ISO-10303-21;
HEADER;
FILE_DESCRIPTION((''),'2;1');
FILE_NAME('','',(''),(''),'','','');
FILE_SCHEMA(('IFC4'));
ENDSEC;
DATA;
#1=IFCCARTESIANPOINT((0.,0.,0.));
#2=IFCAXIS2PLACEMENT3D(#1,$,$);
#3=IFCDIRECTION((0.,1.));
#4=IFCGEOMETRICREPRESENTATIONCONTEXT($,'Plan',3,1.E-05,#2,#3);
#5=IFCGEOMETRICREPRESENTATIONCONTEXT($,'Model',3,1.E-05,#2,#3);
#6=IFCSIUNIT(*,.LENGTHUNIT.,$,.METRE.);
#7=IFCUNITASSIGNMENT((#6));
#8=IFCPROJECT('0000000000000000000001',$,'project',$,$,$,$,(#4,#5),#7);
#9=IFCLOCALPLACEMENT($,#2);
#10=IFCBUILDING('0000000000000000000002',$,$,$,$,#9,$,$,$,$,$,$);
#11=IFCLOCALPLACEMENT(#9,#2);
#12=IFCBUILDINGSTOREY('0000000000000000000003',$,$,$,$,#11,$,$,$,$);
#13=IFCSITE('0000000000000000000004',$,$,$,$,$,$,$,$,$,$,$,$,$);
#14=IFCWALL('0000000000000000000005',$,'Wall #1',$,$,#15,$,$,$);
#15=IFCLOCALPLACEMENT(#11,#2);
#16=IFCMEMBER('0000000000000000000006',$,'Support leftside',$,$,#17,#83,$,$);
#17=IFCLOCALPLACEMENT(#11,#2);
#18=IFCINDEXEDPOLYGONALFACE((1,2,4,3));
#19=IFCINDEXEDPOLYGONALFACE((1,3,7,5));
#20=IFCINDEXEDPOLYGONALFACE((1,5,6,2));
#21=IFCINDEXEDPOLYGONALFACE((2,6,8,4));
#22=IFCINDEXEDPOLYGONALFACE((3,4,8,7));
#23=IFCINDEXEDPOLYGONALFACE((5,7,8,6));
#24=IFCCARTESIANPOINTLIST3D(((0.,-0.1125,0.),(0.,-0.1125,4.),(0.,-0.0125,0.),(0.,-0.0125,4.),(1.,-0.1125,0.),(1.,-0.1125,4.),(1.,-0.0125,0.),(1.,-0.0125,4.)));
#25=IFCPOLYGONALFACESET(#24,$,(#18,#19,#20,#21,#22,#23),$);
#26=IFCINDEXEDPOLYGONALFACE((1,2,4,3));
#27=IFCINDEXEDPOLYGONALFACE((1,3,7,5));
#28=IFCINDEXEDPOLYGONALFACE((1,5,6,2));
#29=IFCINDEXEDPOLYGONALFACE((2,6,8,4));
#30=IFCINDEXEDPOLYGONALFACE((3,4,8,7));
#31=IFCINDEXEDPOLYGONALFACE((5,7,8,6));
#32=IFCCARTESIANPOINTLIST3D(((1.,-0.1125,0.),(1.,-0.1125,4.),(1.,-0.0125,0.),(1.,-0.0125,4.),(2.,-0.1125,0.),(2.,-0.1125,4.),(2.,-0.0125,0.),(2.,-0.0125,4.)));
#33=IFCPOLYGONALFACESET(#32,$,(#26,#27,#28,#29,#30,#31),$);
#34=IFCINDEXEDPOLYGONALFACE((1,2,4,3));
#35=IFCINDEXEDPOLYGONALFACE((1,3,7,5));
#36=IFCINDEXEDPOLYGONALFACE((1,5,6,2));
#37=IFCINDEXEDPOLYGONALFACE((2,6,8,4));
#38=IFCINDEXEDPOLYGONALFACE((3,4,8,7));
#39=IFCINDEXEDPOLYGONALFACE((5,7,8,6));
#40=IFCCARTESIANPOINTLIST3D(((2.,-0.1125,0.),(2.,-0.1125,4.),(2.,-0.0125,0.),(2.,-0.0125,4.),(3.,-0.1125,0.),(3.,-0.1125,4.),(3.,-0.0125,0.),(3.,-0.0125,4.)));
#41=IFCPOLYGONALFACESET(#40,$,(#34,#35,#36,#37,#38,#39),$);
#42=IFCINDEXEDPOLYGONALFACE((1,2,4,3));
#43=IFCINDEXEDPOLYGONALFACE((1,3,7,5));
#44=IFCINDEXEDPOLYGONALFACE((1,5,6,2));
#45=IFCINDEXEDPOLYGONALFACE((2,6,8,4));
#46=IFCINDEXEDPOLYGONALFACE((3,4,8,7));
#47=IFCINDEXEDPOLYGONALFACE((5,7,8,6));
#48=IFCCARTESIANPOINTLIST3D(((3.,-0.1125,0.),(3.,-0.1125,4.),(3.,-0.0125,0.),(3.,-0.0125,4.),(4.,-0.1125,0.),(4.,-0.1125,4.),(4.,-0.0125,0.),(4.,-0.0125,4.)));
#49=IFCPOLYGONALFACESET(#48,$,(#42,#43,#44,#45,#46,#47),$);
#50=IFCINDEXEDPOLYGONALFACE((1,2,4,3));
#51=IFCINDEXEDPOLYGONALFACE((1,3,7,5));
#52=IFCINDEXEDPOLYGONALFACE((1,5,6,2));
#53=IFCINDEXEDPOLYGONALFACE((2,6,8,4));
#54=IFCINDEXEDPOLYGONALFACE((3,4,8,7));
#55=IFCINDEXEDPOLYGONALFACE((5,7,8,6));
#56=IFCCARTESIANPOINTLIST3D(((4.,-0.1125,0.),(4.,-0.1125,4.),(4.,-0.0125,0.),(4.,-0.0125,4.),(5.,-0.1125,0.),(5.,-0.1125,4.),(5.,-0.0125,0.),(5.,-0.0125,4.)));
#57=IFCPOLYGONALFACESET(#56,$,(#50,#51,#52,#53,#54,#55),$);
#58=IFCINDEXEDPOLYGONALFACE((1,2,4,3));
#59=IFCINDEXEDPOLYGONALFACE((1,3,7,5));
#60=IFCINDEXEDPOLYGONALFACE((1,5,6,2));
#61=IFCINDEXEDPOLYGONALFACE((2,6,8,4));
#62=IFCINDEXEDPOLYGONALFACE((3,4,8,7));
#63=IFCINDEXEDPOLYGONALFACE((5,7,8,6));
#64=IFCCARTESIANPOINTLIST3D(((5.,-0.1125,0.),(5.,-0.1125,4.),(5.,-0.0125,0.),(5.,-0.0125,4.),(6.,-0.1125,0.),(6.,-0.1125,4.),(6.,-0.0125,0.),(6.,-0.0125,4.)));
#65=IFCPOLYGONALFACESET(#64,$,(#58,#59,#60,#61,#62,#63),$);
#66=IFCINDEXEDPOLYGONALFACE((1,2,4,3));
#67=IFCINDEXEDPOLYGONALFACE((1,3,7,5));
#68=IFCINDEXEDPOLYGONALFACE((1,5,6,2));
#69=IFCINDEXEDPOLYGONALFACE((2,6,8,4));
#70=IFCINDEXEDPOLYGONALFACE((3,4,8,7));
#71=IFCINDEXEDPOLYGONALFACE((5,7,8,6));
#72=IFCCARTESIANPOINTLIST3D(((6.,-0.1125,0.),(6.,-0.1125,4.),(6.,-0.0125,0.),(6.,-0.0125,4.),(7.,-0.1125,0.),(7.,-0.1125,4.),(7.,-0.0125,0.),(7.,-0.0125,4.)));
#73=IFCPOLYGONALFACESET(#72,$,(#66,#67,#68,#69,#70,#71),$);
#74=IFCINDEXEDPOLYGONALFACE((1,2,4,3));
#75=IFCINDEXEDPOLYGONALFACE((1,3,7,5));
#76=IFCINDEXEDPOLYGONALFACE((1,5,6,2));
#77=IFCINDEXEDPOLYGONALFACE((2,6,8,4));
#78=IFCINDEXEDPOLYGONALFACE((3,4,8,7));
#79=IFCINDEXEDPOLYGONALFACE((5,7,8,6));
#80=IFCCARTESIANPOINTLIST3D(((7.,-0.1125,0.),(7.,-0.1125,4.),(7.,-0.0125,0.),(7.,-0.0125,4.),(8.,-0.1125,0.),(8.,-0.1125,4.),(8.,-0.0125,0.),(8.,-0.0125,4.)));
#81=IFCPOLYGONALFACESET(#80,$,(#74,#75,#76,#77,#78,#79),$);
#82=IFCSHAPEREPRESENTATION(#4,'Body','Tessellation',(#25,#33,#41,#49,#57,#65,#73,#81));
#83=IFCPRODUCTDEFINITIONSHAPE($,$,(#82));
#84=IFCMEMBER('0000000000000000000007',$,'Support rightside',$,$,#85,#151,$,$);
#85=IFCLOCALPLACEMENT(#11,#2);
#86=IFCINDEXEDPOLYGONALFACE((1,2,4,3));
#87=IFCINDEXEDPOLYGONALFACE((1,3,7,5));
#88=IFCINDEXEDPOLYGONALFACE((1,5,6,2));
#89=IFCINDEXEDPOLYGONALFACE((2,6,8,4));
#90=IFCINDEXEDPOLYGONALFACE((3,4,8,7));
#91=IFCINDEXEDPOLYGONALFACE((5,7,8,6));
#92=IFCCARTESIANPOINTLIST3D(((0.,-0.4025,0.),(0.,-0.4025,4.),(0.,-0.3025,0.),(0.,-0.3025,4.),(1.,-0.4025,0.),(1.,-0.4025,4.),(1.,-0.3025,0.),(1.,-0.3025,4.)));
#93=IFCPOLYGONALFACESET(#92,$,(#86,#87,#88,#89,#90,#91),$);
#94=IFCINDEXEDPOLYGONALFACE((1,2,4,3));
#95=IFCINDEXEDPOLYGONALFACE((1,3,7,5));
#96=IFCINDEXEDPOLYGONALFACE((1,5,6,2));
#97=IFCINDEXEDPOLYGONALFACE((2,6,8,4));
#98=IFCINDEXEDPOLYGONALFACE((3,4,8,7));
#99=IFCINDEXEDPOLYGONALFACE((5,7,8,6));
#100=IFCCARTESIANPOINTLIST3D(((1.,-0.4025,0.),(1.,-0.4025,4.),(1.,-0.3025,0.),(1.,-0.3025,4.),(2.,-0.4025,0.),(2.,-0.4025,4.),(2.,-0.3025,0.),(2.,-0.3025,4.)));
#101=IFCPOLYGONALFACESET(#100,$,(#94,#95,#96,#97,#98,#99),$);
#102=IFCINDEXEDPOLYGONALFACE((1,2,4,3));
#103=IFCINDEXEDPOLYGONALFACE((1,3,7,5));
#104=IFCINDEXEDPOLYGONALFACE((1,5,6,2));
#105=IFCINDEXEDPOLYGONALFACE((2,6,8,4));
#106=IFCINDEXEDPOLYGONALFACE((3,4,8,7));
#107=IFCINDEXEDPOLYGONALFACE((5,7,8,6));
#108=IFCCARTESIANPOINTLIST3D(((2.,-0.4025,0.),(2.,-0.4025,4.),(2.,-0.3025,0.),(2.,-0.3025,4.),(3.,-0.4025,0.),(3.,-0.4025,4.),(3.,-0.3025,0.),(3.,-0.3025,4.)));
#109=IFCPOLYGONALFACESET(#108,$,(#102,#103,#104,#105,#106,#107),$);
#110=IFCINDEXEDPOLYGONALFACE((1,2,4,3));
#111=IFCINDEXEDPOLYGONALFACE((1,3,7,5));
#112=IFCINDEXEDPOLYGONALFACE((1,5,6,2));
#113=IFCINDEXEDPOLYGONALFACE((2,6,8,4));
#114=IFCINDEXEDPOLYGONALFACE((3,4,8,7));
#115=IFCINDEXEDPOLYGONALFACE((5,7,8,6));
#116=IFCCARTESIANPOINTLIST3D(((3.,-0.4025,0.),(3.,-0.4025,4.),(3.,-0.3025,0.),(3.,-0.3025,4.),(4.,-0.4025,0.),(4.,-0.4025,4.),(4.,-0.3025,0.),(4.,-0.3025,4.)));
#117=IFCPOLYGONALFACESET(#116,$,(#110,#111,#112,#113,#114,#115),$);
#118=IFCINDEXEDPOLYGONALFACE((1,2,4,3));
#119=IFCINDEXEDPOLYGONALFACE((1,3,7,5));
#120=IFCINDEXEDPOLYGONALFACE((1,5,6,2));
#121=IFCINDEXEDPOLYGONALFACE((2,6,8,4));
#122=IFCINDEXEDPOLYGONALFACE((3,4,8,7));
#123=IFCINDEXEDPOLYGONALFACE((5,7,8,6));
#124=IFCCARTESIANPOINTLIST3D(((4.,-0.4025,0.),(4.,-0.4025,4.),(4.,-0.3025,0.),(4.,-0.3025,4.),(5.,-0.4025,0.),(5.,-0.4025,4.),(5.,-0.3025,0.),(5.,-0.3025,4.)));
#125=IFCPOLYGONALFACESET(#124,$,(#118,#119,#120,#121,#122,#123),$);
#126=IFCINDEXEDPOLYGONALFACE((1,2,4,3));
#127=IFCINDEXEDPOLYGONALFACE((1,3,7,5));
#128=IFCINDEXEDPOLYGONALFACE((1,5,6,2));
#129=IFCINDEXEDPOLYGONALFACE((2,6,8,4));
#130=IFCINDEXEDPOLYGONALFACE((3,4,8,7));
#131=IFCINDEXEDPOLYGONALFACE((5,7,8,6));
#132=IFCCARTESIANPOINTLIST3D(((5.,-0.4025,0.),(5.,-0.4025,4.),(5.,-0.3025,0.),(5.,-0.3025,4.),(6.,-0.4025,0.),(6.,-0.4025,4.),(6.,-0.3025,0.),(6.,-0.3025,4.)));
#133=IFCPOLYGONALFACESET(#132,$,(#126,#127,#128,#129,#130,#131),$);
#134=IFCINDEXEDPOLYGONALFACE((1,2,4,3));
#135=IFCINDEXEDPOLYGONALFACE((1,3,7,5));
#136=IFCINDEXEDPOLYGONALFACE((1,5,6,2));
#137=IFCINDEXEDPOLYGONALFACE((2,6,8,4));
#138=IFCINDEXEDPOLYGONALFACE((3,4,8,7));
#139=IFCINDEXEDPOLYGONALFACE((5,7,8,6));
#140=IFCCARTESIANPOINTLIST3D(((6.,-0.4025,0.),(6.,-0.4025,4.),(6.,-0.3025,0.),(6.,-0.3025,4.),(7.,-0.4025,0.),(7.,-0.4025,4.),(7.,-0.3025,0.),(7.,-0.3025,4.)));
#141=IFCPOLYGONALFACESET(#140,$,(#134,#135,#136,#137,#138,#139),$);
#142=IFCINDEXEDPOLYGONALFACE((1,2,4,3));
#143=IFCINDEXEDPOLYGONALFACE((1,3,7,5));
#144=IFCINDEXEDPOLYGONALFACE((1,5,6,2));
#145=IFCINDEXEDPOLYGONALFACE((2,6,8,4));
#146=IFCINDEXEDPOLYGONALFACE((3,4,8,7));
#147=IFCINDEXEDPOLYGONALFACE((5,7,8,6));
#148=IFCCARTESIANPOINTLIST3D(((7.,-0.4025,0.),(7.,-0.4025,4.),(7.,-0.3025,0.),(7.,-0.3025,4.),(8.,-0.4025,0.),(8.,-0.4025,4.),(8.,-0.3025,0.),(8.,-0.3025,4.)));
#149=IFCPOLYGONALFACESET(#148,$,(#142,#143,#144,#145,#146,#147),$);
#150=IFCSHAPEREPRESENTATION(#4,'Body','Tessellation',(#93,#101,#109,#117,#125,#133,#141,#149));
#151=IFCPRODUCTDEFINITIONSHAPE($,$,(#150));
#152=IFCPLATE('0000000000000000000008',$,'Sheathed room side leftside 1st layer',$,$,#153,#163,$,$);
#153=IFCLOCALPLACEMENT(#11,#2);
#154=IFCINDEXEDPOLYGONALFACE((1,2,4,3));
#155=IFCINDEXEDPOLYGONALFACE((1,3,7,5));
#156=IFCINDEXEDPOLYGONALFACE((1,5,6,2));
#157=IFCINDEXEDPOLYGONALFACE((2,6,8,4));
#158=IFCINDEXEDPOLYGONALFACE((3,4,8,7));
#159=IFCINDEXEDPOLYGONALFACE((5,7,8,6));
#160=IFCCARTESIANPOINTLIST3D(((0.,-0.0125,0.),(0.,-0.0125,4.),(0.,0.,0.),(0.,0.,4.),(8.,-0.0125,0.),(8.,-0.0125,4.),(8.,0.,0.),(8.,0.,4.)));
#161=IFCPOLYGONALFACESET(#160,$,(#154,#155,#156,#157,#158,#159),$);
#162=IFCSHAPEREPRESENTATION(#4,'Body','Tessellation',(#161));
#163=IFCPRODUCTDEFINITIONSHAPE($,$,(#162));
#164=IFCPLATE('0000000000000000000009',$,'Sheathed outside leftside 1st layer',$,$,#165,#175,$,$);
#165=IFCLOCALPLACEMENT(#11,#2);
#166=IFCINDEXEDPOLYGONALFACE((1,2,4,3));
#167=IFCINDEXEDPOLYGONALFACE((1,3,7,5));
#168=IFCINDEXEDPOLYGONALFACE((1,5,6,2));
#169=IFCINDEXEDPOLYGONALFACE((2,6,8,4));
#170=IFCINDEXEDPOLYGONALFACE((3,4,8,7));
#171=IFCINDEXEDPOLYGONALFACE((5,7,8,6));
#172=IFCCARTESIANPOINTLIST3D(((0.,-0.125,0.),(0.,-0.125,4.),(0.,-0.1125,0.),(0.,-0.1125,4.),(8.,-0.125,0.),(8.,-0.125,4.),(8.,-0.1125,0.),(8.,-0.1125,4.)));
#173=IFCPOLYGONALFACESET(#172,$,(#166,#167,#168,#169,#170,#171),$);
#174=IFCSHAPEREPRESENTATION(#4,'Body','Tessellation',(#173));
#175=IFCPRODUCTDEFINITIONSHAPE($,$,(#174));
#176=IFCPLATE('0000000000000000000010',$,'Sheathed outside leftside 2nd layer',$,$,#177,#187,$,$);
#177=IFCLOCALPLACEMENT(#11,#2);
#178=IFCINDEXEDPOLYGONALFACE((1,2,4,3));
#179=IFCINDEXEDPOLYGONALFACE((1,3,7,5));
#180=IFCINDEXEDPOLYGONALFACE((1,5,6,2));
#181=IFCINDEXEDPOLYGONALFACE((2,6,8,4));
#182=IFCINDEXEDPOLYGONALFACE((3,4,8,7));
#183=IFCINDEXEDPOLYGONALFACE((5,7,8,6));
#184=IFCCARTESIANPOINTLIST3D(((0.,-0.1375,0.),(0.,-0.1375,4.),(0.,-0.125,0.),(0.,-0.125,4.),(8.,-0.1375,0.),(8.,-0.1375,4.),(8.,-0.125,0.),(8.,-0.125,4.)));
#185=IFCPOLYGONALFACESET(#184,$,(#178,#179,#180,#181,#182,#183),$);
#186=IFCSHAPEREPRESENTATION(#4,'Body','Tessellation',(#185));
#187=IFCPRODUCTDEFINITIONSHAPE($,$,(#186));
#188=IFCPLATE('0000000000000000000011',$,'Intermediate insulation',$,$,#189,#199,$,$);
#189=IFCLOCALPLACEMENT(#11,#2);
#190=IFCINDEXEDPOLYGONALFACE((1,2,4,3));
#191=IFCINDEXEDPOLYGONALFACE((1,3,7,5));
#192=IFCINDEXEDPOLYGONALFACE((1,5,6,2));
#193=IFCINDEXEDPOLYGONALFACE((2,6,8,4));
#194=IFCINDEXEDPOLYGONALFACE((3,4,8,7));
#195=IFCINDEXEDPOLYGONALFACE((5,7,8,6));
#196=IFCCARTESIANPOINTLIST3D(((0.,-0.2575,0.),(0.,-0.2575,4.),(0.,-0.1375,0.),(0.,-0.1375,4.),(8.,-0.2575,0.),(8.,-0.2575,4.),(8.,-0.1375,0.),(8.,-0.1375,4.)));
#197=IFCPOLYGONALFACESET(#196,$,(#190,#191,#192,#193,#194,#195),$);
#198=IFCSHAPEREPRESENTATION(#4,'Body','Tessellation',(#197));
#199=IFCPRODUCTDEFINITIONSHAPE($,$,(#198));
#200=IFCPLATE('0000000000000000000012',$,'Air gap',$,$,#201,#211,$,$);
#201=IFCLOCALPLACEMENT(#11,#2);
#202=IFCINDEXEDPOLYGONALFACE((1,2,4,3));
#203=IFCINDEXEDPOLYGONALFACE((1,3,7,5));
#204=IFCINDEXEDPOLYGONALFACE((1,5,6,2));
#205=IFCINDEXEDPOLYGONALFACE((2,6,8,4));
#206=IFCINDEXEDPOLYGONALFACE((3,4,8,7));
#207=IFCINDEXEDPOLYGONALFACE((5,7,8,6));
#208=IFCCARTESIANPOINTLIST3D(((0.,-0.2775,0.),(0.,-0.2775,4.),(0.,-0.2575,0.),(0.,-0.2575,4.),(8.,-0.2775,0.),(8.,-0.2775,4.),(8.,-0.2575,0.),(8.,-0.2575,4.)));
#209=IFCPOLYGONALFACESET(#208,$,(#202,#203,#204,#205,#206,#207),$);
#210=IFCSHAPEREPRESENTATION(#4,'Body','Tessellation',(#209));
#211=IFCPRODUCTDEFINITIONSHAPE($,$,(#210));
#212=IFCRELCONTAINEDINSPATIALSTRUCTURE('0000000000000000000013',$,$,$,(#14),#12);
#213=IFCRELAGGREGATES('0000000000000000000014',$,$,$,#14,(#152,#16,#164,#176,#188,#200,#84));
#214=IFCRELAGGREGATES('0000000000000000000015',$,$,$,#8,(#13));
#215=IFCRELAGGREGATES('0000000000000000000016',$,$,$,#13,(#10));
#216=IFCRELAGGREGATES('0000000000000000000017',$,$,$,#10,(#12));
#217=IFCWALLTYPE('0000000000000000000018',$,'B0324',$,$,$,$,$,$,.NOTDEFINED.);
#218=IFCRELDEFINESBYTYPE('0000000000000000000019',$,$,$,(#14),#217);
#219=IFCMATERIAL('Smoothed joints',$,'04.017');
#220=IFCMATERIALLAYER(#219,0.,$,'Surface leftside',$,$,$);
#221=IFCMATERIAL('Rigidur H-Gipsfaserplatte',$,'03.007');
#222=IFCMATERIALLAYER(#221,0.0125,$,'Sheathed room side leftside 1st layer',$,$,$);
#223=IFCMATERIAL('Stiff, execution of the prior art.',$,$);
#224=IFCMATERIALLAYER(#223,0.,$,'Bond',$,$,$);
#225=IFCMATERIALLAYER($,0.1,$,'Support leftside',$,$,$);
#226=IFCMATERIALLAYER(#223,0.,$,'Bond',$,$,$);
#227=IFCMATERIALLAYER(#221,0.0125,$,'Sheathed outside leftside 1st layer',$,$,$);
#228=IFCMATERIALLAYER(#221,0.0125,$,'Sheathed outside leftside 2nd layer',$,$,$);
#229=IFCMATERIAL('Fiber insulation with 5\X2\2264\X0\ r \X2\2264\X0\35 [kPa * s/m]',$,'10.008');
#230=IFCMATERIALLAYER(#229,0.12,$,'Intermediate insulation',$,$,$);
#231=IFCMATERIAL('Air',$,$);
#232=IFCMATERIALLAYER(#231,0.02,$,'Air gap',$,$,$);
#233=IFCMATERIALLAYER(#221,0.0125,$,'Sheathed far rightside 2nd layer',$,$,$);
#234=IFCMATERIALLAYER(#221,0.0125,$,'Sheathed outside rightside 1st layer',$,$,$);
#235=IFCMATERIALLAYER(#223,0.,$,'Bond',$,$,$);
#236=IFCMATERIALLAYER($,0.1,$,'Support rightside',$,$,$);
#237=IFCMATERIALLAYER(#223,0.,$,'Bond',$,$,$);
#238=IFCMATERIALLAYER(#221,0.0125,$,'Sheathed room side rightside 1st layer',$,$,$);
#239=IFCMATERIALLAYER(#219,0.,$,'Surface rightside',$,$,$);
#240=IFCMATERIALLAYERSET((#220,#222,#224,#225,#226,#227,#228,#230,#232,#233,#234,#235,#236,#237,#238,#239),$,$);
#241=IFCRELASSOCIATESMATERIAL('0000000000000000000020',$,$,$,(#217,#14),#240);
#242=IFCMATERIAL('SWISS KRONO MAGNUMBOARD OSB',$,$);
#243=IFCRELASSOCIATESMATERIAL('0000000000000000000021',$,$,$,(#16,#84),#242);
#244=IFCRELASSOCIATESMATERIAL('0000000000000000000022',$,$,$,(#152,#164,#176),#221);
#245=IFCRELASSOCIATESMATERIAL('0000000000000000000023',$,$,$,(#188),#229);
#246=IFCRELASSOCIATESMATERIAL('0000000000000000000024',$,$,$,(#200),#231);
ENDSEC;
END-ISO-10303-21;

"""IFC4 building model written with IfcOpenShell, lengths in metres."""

from ifc_helpers import new_model, si_unit, direction, frame, frame_2d, origin, origin_with_axes, place, context, project, spatial, rectangle, extrude, material, layer, layer_set, type_object, element, aggregate, save


model = new_model("IFC4")

# Units and contexts
plan_context = context("Plan", 3, precision=1e-05, world=origin(), true_north=direction((0.0, 1.0)))
model_context = context("Model", 3, precision=1e-05, world=origin(), true_north=direction((0.0, 1.0)))
ifc_project = project(units=[si_unit("LENGTHUNIT", "METRE")], contexts=[plan_context, model_context])

# Site, building, storey
site = spatial("IfcSite", under=ifc_project)
building_placement = place(None, origin())
building = spatial("IfcBuilding", under=site, at=building_placement)
storey_placement = place(building_placement, origin())
storey = spatial("IfcBuildingStorey", under=building, at=storey_placement)

# Wall, members, plates
ifc_material_1 = material(Name="Smoothed joints", Category="04.017")
ifc_layer_1 = layer(ifc_material_1, 0.0, Name="Surface leftside")
ifc_material_2 = material(Name="Rigidur H-Gipsfaserplatte", Category="03.007")
ifc_layer_2 = layer(ifc_material_2, 0.0125, Name="Sheathed room side leftside 1st layer")
ifc_material_3 = material(Name="Stiff, execution of the prior art.")
ifc_layer_3 = layer(ifc_material_3, 0.0, Name="Bond")
ifc_layer_4 = layer(None, 0.1, Name="Support leftside")
ifc_layer_5 = layer(ifc_material_3, 0.0, Name="Bond")
ifc_layer_6 = layer(ifc_material_2, 0.0125, Name="Sheathed outside leftside 1st layer")
ifc_layer_7 = layer(ifc_material_2, 0.0125, Name="Sheathed outside leftside 2nd layer")
ifc_material_4 = material(Name="Fiber insulation with 5≤ r ≤35 [kPa * s/m]", Category="10.008")
ifc_layer_8 = layer(ifc_material_4, 0.12, Name="Intermediate insulation")
ifc_material_5 = material(Name="Air")
ifc_layer_9 = layer(ifc_material_5, 0.02, Name="Air gap")
ifc_layer_10 = layer(ifc_material_2, 0.0125, Name="Sheathed far rightside 2nd layer")
ifc_layer_11 = layer(ifc_material_2, 0.0125, Name="Sheathed outside rightside 1st layer")
ifc_layer_12 = layer(ifc_material_3, 0.0, Name="Bond")
ifc_layer_13 = layer(None, 0.1, Name="Support rightside")
ifc_layer_14 = layer(ifc_material_3, 0.0, Name="Bond")
ifc_layer_15 = layer(ifc_material_2, 0.0125, Name="Sheathed room side rightside 1st layer")
ifc_layer_16 = layer(ifc_material_1, 0.0, Name="Surface rightside")
ifc_layer_set = layer_set([ifc_layer_1, ifc_layer_2, ifc_layer_3, ifc_layer_4, ifc_layer_5, ifc_layer_6, ifc_layer_7, ifc_layer_8, ifc_layer_9, ifc_layer_10, ifc_layer_11, ifc_layer_12, ifc_layer_13, ifc_layer_14, ifc_layer_15, ifc_layer_16])
wall_type = type_object("IfcWallType", Name="B0324", PredefinedType="NOTDEFINED", material=ifc_layer_set)
wall_placement = place(None, frame((0.0, 0.0, 0.0), z_axis=(0.0, -1.0, 0.0), x_axis=(1.0, 0.0, 0.0)))
wall = element("IfcWall", 1, at=wall_placement, inside=storey, type_object=wall_type, material=ifc_layer_set, Name="Wall #1")
ifc_material_6 = material(Name="SWISS KRONO MAGNUMBOARD OSB")
member_1_placement = place(wall_placement, origin())
member_1 = element("IfcMember", 2, at=member_1_placement, material=ifc_material_6, Name="Support leftside", context=plan_context, shape_type="SweptSolid", body=[
    extrude(rectangle(XDim=1.0, YDim=0.1, at=frame_2d((0.5, 0.05), x_axis=(1.0, 0.0))), frame((0.0, 4.0, 0.0125), z_axis=(0.0, -1.0, 0.0), x_axis=(1.0, 0.0, 0.0)), (0.0, 0.0, 1.0), 4.0),
    extrude(rectangle(XDim=1.0, YDim=0.1, at=frame_2d((0.5, 0.05), x_axis=(1.0, 0.0))), frame((1.0, 4.0, 0.0125), z_axis=(0.0, -1.0, 0.0), x_axis=(1.0, 0.0, 0.0)), (0.0, 0.0, 1.0), 4.0),
    extrude(rectangle(XDim=1.0, YDim=0.1, at=frame_2d((0.5, 0.05), x_axis=(1.0, 0.0))), frame((2.0, 4.0, 0.0125), z_axis=(0.0, -1.0, 0.0), x_axis=(1.0, 0.0, 0.0)), (0.0, 0.0, 1.0), 4.0),
    extrude(rectangle(XDim=1.0, YDim=0.1, at=frame_2d((0.5, 0.05), x_axis=(1.0, 0.0))), frame((3.0, 4.0, 0.0125), z_axis=(0.0, -1.0, 0.0), x_axis=(1.0, 0.0, 0.0)), (0.0, 0.0, 1.0), 4.0),
    extrude(rectangle(XDim=1.0, YDim=0.1, at=frame_2d((0.5, 0.05), x_axis=(1.0, 0.0))), frame((4.0, 4.0, 0.0125), z_axis=(0.0, -1.0, 0.0), x_axis=(1.0, 0.0, 0.0)), (0.0, 0.0, 1.0), 4.0),
    extrude(rectangle(XDim=1.0, YDim=0.1, at=frame_2d((0.5, 0.05), x_axis=(1.0, 0.0))), frame((5.0, 4.0, 0.0125), z_axis=(0.0, -1.0, 0.0), x_axis=(1.0, 0.0, 0.0)), (0.0, 0.0, 1.0), 4.0),
    extrude(rectangle(XDim=1.0, YDim=0.1, at=frame_2d((0.5, 0.05), x_axis=(1.0, 0.0))), frame((6.0, 4.0, 0.0125), z_axis=(0.0, -1.0, 0.0), x_axis=(1.0, 0.0, 0.0)), (0.0, 0.0, 1.0), 4.0),
    extrude(rectangle(XDim=1.0, YDim=0.1, at=frame_2d((0.5, 0.05), x_axis=(1.0, 0.0))), frame((7.0, 4.0, 0.0125), z_axis=(0.0, -1.0, 0.0), x_axis=(1.0, 0.0, 0.0)), (0.0, 0.0, 1.0), 4.0),
])
member_2_placement = place(wall_placement, origin())
member_2 = element("IfcMember", 3, at=member_2_placement, material=ifc_material_6, Name="Support rightside", context=plan_context, shape_type="SweptSolid", body=[
    extrude(rectangle(XDim=1.0, YDim=0.1, at=frame_2d((0.5, 0.05), x_axis=(1.0, 0.0))), frame((0.0, 4.0, 0.3025), z_axis=(0.0, -1.0, 0.0), x_axis=(1.0, 0.0, 0.0)), (0.0, 0.0, 1.0), 4.0),
    extrude(rectangle(XDim=1.0, YDim=0.1, at=frame_2d((0.5, 0.05), x_axis=(1.0, 0.0))), frame((1.0, 4.0, 0.3025), z_axis=(0.0, -1.0, 0.0), x_axis=(1.0, 0.0, 0.0)), (0.0, 0.0, 1.0), 4.0),
    extrude(rectangle(XDim=1.0, YDim=0.1, at=frame_2d((0.5, 0.05), x_axis=(1.0, 0.0))), frame((2.0, 4.0, 0.3025), z_axis=(0.0, -1.0, 0.0), x_axis=(1.0, 0.0, 0.0)), (0.0, 0.0, 1.0), 4.0),
    extrude(rectangle(XDim=1.0, YDim=0.1, at=frame_2d((0.5, 0.05), x_axis=(1.0, 0.0))), frame((3.0, 4.0, 0.3025), z_axis=(0.0, -1.0, 0.0), x_axis=(1.0, 0.0, 0.0)), (0.0, 0.0, 1.0), 4.0),
    extrude(rectangle(XDim=1.0, YDim=0.1, at=frame_2d((0.5, 0.05), x_axis=(1.0, 0.0))), frame((4.0, 4.0, 0.3025), z_axis=(0.0, -1.0, 0.0), x_axis=(1.0, 0.0, 0.0)), (0.0, 0.0, 1.0), 4.0),
    extrude(rectangle(XDim=1.0, YDim=0.1, at=frame_2d((0.5, 0.05), x_axis=(1.0, 0.0))), frame((5.0, 4.0, 0.3025), z_axis=(0.0, -1.0, 0.0), x_axis=(1.0, 0.0, 0.0)), (0.0, 0.0, 1.0), 4.0),
    extrude(rectangle(XDim=1.0, YDim=0.1, at=frame_2d((0.5, 0.05), x_axis=(1.0, 0.0))), frame((6.0, 4.0, 0.3025), z_axis=(0.0, -1.0, 0.0), x_axis=(1.0, 0.0, 0.0)), (0.0, 0.0, 1.0), 4.0),
    extrude(rectangle(XDim=1.0, YDim=0.1, at=frame_2d((0.5, 0.05), x_axis=(1.0, 0.0))), frame((7.0, 4.0, 0.3025), z_axis=(0.0, -1.0, 0.0), x_axis=(1.0, 0.0, 0.0)), (0.0, 0.0, 1.0), 4.0),
])
plate_1_placement = place(wall_placement, origin())
plate_1 = element("IfcPlate", 4, at=plate_1_placement, material=ifc_material_2, Name="Sheathed room side leftside 1st layer", context=plan_context, shape_type="SweptSolid", body=[
    extrude(rectangle(XDim=8.0, YDim=4.0, at=frame_2d((4.0, 2.0), x_axis=(1.0, 0.0))), origin_with_axes(), (0.0, 0.0, 1.0), 0.0125),
])
plate_2_placement = place(wall_placement, origin())
plate_2 = element("IfcPlate", 5, at=plate_2_placement, material=ifc_material_2, Name="Sheathed outside leftside 1st layer", context=plan_context, shape_type="SweptSolid", body=[
    extrude(rectangle(XDim=8.0, YDim=4.0, at=frame_2d((4.0, 2.0), x_axis=(1.0, 0.0))), frame((0.0, 0.0, 0.1125), z_axis=(0.0, 0.0, 1.0), x_axis=(1.0, 0.0, 0.0)), (0.0, 0.0, 1.0), 0.0125),
])
plate_3_placement = place(wall_placement, origin())
plate_3 = element("IfcPlate", 6, at=plate_3_placement, material=ifc_material_2, Name="Sheathed outside leftside 2nd layer", context=plan_context, shape_type="SweptSolid", body=[
    extrude(rectangle(XDim=8.0, YDim=4.0, at=frame_2d((4.0, 2.0), x_axis=(1.0, 0.0))), frame((0.0, 0.0, 0.125), z_axis=(0.0, 0.0, 1.0), x_axis=(1.0, 0.0, 0.0)), (0.0, 0.0, 1.0), 0.0125),
])
plate_4_placement = place(wall_placement, origin())
plate_4 = element("IfcPlate", 7, at=plate_4_placement, material=ifc_material_4, Name="Intermediate insulation", context=plan_context, shape_type="SweptSolid", body=[
    extrude(rectangle(XDim=8.0, YDim=4.0, at=frame_2d((4.0, 2.0), x_axis=(1.0, 0.0))), frame((0.0, 0.0, 0.1375), z_axis=(0.0, 0.0, 1.0), x_axis=(1.0, 0.0, 0.0)), (0.0, 0.0, 1.0), 0.12),
])
plate_5_placement = place(wall_placement, origin())
plate_5 = element("IfcPlate", 8, at=plate_5_placement, material=ifc_material_5, Name="Air gap", context=plan_context, shape_type="SweptSolid", body=[
    extrude(rectangle(XDim=8.0, YDim=4.0, at=frame_2d((4.0, 2.0), x_axis=(1.0, 0.0))), frame((0.0, 0.0, 0.2575), z_axis=(0.0, 0.0, 1.0), x_axis=(1.0, 0.0, 0.0)), (0.0, 0.0, 1.0), 0.02),
])
aggregate(wall, [plate_1, member_1, plate_2, plate_3, plate_4, plate_5, member_2])

save(model, "model.ifc")
